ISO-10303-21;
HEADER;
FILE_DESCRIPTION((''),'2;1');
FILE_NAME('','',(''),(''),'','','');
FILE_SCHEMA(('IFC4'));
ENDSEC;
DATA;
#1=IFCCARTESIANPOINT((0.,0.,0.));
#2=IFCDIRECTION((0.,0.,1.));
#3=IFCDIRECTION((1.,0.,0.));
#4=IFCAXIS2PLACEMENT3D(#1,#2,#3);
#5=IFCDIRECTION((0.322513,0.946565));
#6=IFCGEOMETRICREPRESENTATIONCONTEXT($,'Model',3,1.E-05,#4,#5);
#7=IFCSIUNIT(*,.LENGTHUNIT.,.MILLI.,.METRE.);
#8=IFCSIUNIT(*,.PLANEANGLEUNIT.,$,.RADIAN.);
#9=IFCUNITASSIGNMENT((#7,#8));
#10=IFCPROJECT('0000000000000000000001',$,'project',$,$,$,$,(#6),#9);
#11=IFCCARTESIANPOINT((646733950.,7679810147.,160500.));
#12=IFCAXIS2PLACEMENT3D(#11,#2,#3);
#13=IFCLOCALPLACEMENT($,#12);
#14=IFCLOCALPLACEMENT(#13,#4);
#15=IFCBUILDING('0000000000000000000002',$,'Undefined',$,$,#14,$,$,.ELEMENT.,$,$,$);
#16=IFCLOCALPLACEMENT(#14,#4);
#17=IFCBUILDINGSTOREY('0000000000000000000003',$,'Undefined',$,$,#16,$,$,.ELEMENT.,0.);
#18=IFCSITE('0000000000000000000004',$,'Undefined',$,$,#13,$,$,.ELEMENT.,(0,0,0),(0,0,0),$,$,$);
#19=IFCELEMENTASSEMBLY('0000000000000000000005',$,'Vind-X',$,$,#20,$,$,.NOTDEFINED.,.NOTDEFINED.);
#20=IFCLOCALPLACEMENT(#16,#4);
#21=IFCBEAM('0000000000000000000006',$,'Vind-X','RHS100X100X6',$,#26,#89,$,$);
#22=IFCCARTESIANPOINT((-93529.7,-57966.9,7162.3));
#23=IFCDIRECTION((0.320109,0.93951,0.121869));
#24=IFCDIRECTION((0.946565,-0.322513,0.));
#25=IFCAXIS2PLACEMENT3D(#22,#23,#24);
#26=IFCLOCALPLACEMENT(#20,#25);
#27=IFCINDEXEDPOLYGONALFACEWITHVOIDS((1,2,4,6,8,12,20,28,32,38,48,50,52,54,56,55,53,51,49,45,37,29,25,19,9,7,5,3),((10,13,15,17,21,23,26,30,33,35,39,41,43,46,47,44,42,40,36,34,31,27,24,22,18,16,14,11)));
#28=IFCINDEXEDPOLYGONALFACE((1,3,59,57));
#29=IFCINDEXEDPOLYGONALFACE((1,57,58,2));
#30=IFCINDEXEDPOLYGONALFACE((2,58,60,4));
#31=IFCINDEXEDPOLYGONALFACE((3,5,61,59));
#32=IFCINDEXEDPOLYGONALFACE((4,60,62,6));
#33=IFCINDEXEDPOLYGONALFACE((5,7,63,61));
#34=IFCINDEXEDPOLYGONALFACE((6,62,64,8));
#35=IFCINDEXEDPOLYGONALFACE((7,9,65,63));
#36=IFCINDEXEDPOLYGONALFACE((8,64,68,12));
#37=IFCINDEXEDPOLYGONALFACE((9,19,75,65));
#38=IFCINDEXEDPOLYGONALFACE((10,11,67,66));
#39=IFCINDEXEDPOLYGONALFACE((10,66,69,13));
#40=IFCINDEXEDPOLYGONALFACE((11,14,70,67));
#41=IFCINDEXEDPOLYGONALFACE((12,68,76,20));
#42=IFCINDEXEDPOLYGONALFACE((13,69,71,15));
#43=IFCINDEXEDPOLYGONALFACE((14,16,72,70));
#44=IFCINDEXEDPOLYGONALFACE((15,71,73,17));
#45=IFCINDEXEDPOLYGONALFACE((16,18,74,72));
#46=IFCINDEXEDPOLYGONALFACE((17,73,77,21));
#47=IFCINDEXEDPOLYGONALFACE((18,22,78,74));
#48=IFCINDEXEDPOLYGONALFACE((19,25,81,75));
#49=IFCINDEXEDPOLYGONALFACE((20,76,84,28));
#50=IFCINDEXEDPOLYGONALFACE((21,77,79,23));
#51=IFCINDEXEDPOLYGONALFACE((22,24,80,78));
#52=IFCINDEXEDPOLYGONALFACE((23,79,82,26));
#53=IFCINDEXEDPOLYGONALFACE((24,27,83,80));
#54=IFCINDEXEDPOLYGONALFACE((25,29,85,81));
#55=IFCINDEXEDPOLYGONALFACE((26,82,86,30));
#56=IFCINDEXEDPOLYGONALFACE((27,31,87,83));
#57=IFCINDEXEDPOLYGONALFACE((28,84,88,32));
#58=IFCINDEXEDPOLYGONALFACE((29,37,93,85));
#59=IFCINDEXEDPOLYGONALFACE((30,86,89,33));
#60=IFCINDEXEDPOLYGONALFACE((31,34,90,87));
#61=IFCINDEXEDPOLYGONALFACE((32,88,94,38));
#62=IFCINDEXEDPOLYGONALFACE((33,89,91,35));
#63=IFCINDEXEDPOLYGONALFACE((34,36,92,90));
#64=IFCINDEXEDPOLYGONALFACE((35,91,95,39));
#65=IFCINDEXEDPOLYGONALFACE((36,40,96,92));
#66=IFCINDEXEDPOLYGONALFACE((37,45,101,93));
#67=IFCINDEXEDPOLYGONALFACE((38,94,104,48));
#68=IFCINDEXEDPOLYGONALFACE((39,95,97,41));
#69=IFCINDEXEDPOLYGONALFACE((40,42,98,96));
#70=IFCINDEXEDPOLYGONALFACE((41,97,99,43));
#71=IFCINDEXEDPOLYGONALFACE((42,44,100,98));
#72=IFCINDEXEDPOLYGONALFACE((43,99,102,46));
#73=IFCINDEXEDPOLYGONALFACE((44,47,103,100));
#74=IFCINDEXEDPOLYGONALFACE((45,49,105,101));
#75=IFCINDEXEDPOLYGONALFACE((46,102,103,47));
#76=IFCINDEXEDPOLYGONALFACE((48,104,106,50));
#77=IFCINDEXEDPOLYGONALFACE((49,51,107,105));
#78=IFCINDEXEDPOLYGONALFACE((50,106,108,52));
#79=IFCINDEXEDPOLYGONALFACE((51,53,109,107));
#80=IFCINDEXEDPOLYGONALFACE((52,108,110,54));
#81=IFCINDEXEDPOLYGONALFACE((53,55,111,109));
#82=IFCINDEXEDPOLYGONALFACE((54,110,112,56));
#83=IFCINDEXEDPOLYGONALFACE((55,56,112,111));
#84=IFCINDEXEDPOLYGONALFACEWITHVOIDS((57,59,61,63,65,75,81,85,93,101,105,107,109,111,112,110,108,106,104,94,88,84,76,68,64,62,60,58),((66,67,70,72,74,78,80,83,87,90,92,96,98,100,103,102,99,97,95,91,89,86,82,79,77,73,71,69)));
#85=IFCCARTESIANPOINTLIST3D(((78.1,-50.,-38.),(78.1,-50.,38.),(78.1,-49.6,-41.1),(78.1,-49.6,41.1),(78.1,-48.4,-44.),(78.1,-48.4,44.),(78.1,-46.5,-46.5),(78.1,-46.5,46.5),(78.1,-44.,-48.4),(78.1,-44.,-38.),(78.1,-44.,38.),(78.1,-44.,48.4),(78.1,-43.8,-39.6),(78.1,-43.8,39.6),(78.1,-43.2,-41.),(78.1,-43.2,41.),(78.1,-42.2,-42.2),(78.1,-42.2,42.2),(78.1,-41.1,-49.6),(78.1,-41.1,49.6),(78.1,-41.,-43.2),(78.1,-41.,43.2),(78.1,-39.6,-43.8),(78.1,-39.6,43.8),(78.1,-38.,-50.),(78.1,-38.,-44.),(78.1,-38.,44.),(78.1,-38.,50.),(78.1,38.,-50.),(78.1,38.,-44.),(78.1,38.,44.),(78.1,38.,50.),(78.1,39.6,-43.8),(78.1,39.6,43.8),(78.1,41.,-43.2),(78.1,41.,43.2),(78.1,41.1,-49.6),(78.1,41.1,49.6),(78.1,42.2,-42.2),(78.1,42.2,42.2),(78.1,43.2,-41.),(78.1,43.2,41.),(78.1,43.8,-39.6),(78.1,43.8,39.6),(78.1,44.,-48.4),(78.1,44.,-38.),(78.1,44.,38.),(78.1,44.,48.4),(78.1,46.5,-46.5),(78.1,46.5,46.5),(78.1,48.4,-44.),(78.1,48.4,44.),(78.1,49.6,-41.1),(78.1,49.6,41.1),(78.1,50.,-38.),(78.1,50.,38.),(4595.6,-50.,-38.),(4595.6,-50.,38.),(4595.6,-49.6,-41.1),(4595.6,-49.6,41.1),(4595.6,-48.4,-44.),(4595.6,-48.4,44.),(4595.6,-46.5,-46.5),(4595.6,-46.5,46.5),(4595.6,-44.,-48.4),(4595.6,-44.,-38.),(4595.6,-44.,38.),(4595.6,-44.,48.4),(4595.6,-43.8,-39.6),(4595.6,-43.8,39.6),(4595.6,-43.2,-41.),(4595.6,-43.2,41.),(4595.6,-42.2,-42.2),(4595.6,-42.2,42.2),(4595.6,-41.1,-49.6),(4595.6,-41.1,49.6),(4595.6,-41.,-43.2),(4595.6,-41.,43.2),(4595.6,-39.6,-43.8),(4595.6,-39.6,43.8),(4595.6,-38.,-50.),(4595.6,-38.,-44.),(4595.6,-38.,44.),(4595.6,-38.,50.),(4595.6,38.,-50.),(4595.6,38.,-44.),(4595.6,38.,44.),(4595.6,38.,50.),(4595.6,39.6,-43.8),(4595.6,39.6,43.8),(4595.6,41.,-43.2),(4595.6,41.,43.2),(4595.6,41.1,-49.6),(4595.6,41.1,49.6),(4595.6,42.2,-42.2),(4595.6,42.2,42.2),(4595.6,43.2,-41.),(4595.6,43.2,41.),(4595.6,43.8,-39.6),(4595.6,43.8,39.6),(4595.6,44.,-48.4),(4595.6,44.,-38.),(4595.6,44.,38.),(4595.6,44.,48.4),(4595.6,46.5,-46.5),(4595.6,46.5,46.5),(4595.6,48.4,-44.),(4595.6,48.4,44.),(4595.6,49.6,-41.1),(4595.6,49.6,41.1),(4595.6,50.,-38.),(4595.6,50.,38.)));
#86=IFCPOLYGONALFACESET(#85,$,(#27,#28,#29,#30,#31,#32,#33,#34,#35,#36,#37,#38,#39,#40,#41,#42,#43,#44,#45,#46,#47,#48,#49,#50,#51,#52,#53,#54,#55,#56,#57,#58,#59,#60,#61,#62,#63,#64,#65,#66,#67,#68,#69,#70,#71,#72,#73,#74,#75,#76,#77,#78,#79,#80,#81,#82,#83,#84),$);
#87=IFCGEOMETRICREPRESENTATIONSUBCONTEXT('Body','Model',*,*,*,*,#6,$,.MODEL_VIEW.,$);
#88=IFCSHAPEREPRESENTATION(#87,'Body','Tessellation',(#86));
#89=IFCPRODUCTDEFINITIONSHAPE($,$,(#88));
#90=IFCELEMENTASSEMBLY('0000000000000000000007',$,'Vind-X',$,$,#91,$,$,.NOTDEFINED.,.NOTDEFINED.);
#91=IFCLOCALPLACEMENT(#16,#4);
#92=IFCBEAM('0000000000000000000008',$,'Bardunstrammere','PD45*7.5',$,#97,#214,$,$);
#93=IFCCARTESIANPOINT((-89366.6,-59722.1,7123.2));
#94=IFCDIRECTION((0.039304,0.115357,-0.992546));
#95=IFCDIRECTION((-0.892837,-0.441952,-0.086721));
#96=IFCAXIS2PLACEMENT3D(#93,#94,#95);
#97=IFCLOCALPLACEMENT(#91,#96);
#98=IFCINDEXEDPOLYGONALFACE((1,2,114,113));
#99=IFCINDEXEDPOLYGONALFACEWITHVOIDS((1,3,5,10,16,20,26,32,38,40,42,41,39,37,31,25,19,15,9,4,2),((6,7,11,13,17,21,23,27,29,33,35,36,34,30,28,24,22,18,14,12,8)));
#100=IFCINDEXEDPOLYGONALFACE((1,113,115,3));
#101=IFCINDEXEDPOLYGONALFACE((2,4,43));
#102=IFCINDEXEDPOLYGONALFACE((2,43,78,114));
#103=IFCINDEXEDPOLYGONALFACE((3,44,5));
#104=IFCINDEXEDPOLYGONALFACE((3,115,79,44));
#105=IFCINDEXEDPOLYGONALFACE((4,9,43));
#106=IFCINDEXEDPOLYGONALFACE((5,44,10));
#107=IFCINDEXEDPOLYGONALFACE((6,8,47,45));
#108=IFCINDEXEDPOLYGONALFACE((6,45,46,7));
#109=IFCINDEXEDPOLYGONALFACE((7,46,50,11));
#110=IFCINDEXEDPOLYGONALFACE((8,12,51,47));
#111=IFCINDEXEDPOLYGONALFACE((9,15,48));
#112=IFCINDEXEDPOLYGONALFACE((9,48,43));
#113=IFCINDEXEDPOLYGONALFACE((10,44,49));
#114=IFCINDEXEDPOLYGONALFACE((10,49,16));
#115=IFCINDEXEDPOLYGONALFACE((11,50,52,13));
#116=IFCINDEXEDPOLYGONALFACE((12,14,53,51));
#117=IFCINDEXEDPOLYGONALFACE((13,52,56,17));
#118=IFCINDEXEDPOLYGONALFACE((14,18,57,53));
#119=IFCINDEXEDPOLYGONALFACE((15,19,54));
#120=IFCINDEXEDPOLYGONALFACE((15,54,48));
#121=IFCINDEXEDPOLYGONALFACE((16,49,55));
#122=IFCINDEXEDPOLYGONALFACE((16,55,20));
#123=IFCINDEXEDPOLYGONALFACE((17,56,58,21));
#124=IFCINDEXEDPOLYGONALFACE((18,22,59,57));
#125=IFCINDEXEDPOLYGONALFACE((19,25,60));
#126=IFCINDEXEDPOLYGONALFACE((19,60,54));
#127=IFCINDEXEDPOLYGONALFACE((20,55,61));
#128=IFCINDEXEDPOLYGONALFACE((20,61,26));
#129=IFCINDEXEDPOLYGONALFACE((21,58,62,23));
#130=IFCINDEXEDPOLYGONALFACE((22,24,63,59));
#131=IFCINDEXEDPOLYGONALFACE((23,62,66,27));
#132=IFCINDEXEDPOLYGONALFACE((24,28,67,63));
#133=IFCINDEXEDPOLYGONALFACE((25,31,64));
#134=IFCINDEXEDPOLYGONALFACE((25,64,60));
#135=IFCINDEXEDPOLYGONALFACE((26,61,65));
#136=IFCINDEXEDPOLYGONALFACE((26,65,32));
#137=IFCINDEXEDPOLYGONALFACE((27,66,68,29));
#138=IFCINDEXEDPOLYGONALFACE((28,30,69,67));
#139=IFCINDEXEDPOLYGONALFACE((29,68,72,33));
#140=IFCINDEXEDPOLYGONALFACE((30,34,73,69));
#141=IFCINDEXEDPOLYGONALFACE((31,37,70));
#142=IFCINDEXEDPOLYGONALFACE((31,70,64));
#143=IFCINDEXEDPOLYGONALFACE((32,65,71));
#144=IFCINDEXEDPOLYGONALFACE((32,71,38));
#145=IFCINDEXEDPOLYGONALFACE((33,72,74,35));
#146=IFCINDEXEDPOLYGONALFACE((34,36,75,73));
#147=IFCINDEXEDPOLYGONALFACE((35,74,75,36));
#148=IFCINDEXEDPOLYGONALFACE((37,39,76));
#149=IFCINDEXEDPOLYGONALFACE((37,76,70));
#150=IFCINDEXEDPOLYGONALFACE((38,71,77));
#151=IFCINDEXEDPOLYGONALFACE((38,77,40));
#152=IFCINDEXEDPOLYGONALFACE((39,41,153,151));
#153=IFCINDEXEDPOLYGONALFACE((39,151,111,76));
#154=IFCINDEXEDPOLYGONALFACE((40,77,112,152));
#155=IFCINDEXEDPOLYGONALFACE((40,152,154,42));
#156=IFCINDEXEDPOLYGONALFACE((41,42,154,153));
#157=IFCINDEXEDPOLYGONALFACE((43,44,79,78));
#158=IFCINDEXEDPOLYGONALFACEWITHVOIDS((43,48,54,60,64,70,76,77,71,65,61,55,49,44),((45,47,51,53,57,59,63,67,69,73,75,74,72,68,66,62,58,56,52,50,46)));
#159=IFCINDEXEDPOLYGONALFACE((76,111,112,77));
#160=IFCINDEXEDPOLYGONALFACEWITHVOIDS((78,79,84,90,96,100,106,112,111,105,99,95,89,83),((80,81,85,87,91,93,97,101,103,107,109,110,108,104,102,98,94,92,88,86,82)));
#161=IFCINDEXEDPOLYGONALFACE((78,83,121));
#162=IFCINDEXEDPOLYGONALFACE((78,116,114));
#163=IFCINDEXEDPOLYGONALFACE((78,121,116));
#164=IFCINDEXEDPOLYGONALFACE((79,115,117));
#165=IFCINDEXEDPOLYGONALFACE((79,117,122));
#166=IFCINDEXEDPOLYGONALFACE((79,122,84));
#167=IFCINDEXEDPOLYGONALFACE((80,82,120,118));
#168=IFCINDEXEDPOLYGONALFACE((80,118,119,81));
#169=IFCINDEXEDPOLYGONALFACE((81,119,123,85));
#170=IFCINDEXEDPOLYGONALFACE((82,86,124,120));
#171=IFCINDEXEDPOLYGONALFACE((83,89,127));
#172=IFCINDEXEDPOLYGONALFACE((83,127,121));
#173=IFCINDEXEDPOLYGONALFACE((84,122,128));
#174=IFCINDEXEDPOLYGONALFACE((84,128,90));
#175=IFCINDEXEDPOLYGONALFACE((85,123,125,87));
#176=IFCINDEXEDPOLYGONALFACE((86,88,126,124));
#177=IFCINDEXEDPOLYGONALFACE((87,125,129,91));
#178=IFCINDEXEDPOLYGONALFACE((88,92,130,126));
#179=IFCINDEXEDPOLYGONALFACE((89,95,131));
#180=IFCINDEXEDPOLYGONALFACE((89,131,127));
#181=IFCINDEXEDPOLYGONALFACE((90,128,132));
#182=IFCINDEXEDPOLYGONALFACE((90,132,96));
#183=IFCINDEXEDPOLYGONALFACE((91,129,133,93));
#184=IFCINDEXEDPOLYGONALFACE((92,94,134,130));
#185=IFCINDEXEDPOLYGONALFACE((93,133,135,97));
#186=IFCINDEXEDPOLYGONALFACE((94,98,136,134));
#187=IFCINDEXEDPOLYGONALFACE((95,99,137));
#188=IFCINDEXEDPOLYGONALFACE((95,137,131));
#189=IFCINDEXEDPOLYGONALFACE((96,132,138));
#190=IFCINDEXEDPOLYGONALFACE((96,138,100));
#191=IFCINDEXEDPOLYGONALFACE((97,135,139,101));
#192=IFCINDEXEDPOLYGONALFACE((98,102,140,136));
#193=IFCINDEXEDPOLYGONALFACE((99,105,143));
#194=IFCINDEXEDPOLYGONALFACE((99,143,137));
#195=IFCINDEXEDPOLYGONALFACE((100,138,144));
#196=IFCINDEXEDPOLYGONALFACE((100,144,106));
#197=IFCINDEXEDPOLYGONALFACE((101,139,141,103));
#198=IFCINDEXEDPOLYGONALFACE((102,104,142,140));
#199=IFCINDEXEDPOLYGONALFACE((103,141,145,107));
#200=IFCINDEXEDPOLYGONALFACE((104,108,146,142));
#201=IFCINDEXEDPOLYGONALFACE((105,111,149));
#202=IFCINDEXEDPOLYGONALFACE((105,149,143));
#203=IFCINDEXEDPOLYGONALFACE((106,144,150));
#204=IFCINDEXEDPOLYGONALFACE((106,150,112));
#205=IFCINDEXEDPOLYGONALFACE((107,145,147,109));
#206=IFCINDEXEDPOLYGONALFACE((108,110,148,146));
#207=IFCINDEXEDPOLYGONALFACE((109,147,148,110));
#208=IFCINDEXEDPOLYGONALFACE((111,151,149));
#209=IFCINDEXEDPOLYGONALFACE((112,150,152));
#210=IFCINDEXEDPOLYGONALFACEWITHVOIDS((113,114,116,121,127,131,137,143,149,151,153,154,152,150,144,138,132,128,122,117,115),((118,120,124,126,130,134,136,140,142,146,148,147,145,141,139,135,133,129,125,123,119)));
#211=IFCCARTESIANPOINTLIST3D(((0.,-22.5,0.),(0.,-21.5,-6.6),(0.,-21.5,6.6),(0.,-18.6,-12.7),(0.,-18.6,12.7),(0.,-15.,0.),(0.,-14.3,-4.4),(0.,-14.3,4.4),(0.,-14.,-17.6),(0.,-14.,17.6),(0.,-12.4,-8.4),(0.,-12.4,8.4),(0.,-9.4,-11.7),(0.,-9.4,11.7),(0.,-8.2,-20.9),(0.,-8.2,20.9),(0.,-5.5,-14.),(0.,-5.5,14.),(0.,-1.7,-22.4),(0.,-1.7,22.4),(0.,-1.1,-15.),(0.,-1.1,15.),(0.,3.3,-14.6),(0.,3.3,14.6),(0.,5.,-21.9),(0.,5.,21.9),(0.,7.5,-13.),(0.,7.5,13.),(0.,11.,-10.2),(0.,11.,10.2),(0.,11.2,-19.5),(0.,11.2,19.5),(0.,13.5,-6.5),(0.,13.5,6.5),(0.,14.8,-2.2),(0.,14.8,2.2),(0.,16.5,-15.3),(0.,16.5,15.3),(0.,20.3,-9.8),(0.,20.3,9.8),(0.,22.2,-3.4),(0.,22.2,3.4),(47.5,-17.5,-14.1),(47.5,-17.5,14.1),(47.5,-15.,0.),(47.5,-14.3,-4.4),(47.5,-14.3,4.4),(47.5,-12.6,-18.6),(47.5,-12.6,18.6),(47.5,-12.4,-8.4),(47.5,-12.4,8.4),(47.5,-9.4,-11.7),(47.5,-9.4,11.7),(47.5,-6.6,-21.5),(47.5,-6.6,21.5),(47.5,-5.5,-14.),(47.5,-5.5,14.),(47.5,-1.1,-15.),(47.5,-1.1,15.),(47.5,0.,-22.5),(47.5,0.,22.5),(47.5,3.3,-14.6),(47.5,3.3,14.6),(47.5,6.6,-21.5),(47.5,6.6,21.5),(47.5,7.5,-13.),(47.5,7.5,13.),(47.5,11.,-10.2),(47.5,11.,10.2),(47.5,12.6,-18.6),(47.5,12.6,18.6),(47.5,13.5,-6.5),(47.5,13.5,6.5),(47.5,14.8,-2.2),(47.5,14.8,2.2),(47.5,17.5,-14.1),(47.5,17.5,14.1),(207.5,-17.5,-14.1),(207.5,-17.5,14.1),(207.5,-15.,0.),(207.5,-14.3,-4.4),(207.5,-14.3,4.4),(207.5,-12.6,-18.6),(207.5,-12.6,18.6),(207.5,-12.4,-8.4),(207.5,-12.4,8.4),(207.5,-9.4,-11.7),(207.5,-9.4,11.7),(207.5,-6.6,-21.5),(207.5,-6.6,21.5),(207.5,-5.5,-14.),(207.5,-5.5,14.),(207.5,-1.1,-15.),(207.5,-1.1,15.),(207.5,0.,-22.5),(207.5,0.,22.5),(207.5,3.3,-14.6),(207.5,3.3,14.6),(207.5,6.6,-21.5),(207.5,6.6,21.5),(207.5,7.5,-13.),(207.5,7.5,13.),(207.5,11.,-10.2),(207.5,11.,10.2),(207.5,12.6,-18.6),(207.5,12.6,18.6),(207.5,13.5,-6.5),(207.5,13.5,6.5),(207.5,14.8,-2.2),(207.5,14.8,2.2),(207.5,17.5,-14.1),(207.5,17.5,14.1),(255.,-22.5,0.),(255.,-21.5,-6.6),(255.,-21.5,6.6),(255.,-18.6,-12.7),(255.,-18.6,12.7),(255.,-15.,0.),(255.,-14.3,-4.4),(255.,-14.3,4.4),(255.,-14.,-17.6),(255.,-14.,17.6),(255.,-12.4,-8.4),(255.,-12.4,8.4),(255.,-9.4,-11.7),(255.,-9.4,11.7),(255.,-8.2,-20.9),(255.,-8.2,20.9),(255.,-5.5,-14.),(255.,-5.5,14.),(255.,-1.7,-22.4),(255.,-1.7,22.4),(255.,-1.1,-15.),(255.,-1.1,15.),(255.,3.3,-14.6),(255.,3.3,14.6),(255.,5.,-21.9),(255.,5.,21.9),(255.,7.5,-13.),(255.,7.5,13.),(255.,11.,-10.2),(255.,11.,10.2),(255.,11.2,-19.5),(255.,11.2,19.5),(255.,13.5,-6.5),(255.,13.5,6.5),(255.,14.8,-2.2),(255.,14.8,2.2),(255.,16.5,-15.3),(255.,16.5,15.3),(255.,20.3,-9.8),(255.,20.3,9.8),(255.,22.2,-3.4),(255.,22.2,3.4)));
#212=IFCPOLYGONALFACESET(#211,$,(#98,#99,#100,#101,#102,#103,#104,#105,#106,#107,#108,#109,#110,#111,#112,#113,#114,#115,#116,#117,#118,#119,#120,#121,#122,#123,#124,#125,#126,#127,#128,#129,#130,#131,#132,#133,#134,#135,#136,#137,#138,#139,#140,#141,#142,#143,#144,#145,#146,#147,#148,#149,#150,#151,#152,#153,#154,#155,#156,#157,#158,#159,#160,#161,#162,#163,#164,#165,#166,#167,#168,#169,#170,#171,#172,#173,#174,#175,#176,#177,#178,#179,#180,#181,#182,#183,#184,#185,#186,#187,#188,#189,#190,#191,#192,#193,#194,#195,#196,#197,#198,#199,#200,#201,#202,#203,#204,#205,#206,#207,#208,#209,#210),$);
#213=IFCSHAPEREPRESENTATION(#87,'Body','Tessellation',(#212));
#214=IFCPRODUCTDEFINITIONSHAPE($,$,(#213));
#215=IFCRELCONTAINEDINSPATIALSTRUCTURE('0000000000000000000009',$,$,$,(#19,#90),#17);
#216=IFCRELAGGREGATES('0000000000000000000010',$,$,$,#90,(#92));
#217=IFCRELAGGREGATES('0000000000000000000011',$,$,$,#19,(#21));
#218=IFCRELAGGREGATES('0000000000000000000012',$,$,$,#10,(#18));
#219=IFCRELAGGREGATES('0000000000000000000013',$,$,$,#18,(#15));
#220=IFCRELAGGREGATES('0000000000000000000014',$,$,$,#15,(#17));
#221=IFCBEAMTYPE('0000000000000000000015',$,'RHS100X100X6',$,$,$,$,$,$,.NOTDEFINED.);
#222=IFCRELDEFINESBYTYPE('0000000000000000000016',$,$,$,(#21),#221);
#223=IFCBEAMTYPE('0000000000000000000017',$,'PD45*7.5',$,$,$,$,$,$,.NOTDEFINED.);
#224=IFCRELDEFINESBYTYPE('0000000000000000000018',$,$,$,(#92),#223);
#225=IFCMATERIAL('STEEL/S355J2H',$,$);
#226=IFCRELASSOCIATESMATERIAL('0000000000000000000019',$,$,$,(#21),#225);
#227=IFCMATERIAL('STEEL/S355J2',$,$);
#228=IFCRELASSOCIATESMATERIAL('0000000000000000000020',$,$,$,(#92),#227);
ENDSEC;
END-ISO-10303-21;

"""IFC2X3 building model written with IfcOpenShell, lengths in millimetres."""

from ifc_helpers import new_model, si_unit, direction, frame, origin_with_axes, origin_2d_with_axis, place, context, subcontext, project, spatial, rectangle, hollow_rectangle, hollow_circle, extrude, boolean, clip, halfspace, material, type_object, element, aggregate, save


model = new_model("IFC2X3")

# Units and contexts
model_context = context("Model", 3, precision=1e-05, world=origin_with_axes(), true_north=direction((0.322513, 0.946565)))
body_context = subcontext(model_context, "Body", "Model", "MODEL_VIEW")
ifc_project = project(units=[si_unit("LENGTHUNIT", "METRE", prefix="MILLI"), si_unit("PLANEANGLEUNIT", "RADIAN")], contexts=[model_context])

# Site, building, storey
site_placement = place(None, frame((646733950.0, 7679810147.0, 160500.0), z_axis=(0.0, 0.0, 1.0), x_axis=(1.0, 0.0, 0.0)))
site = spatial("IfcSite", under=ifc_project, at=site_placement, Name="Undefined", CompositionType="ELEMENT", RefLatitude=(0, 0, 0), RefLongitude=(0, 0, 0))
building_placement = place(site_placement, origin_with_axes())
building = spatial("IfcBuilding", under=site, at=building_placement, Name="Undefined", CompositionType="ELEMENT")
storey_placement = place(building_placement, origin_with_axes())
storey = spatial("IfcBuildingStorey", under=building, at=storey_placement, Name="Undefined", CompositionType="ELEMENT", Elevation=0.0)

# Shared definitions
ifc_material_1 = material(Name="STEEL/S355J2H")

# Element assemblies, beams
assembly_1_placement = place(storey_placement, origin_with_axes())
assembly_1 = element("IfcElementAssembly", 1, at=assembly_1_placement, inside=storey, Name="Vind-X", AssemblyPlace="NOTDEFINED", PredefinedType="NOTDEFINED")
beam_type_1 = type_object("IfcBeamType", Name="RHS100X100X6", PredefinedType="NOTDEFINED")
beam_1_placement = place(assembly_1_placement, frame((-93529.7, -57966.9, 7162.3), z_axis=(0.320109, 0.93951, 0.121869), x_axis=(0.946565, -0.322513, 0.0)))
beam_1 = element("IfcBeam", 2, at=beam_1_placement, type_object=beam_type_1, material=ifc_material_1, Name="Vind-X", Description="RHS100X100X6", context=body_context, shape_type="Clipping", body=[
    clip(clip(extrude(hollow_rectangle(XDim=100.0, YDim=100.0, WallThickness=6.0, InnerFilletRadius=6.0, OuterFilletRadius=12.0, at=origin_2d_with_axis()), frame((4674.6, 0.0, 0.0), z_axis=(-1.0, 0.0, 0.0), x_axis=(0.0, -1.0, 0.0)), (0.0, 0.0, 1.0), 4674.6), halfspace(frame((4595.6, 22.5, 0.0), z_axis=(-1.0, 0.0, 0.0), x_axis=(0.0, 0.0, 1.0)), True)), halfspace(frame((78.1, 22.5, 0.0), z_axis=(1.0, 0.0, 0.0), x_axis=(0.0, 0.0, -1.0)), True)),
])
assembly_2_placement = place(storey_placement, origin_with_axes())
assembly_2 = element("IfcElementAssembly", 3, at=assembly_2_placement, inside=storey, Name="Vind-X", AssemblyPlace="NOTDEFINED", PredefinedType="NOTDEFINED")
ifc_material_2 = material(Name="STEEL/S355J2")
beam_type_2 = type_object("IfcBeamType", Name="PD45*7.5", PredefinedType="NOTDEFINED")
beam_2_placement = place(assembly_2_placement, frame((-89366.6, -59722.1, 7123.2), z_axis=(0.039304, 0.115357, -0.992546), x_axis=(-0.892837, -0.441952, -0.086721)))
beam_2 = element("IfcBeam", 4, at=beam_2_placement, type_object=beam_type_2, material=ifc_material_2, Name="Bardunstrammere", Description="PD45*7.5", context=body_context, shape_type="CSG", body=[
    boolean("DIFFERENCE", extrude(hollow_circle(Radius=22.5, WallThickness=7.5, at=origin_2d_with_axis()), frame((255.0, 0.0, 0.0), z_axis=(-1.0, 0.0, 0.0), x_axis=(0.0, -1.0, 0.0)), (0.0, 0.0, 1.0), 255.0), extrude(rectangle(XDim=35.0, YDim=90.0, at=origin_2d_with_axis()), frame((207.5, 0.0, 0.0), z_axis=(-1.0, 0.0, 0.0), x_axis=(0.0, -1.0, 0.0)), (0.0, 0.0, 1.0), 160.0)),
])

aggregate(assembly_2, [beam_2])

aggregate(assembly_1, [beam_1])

save(model, "model.ifc")
